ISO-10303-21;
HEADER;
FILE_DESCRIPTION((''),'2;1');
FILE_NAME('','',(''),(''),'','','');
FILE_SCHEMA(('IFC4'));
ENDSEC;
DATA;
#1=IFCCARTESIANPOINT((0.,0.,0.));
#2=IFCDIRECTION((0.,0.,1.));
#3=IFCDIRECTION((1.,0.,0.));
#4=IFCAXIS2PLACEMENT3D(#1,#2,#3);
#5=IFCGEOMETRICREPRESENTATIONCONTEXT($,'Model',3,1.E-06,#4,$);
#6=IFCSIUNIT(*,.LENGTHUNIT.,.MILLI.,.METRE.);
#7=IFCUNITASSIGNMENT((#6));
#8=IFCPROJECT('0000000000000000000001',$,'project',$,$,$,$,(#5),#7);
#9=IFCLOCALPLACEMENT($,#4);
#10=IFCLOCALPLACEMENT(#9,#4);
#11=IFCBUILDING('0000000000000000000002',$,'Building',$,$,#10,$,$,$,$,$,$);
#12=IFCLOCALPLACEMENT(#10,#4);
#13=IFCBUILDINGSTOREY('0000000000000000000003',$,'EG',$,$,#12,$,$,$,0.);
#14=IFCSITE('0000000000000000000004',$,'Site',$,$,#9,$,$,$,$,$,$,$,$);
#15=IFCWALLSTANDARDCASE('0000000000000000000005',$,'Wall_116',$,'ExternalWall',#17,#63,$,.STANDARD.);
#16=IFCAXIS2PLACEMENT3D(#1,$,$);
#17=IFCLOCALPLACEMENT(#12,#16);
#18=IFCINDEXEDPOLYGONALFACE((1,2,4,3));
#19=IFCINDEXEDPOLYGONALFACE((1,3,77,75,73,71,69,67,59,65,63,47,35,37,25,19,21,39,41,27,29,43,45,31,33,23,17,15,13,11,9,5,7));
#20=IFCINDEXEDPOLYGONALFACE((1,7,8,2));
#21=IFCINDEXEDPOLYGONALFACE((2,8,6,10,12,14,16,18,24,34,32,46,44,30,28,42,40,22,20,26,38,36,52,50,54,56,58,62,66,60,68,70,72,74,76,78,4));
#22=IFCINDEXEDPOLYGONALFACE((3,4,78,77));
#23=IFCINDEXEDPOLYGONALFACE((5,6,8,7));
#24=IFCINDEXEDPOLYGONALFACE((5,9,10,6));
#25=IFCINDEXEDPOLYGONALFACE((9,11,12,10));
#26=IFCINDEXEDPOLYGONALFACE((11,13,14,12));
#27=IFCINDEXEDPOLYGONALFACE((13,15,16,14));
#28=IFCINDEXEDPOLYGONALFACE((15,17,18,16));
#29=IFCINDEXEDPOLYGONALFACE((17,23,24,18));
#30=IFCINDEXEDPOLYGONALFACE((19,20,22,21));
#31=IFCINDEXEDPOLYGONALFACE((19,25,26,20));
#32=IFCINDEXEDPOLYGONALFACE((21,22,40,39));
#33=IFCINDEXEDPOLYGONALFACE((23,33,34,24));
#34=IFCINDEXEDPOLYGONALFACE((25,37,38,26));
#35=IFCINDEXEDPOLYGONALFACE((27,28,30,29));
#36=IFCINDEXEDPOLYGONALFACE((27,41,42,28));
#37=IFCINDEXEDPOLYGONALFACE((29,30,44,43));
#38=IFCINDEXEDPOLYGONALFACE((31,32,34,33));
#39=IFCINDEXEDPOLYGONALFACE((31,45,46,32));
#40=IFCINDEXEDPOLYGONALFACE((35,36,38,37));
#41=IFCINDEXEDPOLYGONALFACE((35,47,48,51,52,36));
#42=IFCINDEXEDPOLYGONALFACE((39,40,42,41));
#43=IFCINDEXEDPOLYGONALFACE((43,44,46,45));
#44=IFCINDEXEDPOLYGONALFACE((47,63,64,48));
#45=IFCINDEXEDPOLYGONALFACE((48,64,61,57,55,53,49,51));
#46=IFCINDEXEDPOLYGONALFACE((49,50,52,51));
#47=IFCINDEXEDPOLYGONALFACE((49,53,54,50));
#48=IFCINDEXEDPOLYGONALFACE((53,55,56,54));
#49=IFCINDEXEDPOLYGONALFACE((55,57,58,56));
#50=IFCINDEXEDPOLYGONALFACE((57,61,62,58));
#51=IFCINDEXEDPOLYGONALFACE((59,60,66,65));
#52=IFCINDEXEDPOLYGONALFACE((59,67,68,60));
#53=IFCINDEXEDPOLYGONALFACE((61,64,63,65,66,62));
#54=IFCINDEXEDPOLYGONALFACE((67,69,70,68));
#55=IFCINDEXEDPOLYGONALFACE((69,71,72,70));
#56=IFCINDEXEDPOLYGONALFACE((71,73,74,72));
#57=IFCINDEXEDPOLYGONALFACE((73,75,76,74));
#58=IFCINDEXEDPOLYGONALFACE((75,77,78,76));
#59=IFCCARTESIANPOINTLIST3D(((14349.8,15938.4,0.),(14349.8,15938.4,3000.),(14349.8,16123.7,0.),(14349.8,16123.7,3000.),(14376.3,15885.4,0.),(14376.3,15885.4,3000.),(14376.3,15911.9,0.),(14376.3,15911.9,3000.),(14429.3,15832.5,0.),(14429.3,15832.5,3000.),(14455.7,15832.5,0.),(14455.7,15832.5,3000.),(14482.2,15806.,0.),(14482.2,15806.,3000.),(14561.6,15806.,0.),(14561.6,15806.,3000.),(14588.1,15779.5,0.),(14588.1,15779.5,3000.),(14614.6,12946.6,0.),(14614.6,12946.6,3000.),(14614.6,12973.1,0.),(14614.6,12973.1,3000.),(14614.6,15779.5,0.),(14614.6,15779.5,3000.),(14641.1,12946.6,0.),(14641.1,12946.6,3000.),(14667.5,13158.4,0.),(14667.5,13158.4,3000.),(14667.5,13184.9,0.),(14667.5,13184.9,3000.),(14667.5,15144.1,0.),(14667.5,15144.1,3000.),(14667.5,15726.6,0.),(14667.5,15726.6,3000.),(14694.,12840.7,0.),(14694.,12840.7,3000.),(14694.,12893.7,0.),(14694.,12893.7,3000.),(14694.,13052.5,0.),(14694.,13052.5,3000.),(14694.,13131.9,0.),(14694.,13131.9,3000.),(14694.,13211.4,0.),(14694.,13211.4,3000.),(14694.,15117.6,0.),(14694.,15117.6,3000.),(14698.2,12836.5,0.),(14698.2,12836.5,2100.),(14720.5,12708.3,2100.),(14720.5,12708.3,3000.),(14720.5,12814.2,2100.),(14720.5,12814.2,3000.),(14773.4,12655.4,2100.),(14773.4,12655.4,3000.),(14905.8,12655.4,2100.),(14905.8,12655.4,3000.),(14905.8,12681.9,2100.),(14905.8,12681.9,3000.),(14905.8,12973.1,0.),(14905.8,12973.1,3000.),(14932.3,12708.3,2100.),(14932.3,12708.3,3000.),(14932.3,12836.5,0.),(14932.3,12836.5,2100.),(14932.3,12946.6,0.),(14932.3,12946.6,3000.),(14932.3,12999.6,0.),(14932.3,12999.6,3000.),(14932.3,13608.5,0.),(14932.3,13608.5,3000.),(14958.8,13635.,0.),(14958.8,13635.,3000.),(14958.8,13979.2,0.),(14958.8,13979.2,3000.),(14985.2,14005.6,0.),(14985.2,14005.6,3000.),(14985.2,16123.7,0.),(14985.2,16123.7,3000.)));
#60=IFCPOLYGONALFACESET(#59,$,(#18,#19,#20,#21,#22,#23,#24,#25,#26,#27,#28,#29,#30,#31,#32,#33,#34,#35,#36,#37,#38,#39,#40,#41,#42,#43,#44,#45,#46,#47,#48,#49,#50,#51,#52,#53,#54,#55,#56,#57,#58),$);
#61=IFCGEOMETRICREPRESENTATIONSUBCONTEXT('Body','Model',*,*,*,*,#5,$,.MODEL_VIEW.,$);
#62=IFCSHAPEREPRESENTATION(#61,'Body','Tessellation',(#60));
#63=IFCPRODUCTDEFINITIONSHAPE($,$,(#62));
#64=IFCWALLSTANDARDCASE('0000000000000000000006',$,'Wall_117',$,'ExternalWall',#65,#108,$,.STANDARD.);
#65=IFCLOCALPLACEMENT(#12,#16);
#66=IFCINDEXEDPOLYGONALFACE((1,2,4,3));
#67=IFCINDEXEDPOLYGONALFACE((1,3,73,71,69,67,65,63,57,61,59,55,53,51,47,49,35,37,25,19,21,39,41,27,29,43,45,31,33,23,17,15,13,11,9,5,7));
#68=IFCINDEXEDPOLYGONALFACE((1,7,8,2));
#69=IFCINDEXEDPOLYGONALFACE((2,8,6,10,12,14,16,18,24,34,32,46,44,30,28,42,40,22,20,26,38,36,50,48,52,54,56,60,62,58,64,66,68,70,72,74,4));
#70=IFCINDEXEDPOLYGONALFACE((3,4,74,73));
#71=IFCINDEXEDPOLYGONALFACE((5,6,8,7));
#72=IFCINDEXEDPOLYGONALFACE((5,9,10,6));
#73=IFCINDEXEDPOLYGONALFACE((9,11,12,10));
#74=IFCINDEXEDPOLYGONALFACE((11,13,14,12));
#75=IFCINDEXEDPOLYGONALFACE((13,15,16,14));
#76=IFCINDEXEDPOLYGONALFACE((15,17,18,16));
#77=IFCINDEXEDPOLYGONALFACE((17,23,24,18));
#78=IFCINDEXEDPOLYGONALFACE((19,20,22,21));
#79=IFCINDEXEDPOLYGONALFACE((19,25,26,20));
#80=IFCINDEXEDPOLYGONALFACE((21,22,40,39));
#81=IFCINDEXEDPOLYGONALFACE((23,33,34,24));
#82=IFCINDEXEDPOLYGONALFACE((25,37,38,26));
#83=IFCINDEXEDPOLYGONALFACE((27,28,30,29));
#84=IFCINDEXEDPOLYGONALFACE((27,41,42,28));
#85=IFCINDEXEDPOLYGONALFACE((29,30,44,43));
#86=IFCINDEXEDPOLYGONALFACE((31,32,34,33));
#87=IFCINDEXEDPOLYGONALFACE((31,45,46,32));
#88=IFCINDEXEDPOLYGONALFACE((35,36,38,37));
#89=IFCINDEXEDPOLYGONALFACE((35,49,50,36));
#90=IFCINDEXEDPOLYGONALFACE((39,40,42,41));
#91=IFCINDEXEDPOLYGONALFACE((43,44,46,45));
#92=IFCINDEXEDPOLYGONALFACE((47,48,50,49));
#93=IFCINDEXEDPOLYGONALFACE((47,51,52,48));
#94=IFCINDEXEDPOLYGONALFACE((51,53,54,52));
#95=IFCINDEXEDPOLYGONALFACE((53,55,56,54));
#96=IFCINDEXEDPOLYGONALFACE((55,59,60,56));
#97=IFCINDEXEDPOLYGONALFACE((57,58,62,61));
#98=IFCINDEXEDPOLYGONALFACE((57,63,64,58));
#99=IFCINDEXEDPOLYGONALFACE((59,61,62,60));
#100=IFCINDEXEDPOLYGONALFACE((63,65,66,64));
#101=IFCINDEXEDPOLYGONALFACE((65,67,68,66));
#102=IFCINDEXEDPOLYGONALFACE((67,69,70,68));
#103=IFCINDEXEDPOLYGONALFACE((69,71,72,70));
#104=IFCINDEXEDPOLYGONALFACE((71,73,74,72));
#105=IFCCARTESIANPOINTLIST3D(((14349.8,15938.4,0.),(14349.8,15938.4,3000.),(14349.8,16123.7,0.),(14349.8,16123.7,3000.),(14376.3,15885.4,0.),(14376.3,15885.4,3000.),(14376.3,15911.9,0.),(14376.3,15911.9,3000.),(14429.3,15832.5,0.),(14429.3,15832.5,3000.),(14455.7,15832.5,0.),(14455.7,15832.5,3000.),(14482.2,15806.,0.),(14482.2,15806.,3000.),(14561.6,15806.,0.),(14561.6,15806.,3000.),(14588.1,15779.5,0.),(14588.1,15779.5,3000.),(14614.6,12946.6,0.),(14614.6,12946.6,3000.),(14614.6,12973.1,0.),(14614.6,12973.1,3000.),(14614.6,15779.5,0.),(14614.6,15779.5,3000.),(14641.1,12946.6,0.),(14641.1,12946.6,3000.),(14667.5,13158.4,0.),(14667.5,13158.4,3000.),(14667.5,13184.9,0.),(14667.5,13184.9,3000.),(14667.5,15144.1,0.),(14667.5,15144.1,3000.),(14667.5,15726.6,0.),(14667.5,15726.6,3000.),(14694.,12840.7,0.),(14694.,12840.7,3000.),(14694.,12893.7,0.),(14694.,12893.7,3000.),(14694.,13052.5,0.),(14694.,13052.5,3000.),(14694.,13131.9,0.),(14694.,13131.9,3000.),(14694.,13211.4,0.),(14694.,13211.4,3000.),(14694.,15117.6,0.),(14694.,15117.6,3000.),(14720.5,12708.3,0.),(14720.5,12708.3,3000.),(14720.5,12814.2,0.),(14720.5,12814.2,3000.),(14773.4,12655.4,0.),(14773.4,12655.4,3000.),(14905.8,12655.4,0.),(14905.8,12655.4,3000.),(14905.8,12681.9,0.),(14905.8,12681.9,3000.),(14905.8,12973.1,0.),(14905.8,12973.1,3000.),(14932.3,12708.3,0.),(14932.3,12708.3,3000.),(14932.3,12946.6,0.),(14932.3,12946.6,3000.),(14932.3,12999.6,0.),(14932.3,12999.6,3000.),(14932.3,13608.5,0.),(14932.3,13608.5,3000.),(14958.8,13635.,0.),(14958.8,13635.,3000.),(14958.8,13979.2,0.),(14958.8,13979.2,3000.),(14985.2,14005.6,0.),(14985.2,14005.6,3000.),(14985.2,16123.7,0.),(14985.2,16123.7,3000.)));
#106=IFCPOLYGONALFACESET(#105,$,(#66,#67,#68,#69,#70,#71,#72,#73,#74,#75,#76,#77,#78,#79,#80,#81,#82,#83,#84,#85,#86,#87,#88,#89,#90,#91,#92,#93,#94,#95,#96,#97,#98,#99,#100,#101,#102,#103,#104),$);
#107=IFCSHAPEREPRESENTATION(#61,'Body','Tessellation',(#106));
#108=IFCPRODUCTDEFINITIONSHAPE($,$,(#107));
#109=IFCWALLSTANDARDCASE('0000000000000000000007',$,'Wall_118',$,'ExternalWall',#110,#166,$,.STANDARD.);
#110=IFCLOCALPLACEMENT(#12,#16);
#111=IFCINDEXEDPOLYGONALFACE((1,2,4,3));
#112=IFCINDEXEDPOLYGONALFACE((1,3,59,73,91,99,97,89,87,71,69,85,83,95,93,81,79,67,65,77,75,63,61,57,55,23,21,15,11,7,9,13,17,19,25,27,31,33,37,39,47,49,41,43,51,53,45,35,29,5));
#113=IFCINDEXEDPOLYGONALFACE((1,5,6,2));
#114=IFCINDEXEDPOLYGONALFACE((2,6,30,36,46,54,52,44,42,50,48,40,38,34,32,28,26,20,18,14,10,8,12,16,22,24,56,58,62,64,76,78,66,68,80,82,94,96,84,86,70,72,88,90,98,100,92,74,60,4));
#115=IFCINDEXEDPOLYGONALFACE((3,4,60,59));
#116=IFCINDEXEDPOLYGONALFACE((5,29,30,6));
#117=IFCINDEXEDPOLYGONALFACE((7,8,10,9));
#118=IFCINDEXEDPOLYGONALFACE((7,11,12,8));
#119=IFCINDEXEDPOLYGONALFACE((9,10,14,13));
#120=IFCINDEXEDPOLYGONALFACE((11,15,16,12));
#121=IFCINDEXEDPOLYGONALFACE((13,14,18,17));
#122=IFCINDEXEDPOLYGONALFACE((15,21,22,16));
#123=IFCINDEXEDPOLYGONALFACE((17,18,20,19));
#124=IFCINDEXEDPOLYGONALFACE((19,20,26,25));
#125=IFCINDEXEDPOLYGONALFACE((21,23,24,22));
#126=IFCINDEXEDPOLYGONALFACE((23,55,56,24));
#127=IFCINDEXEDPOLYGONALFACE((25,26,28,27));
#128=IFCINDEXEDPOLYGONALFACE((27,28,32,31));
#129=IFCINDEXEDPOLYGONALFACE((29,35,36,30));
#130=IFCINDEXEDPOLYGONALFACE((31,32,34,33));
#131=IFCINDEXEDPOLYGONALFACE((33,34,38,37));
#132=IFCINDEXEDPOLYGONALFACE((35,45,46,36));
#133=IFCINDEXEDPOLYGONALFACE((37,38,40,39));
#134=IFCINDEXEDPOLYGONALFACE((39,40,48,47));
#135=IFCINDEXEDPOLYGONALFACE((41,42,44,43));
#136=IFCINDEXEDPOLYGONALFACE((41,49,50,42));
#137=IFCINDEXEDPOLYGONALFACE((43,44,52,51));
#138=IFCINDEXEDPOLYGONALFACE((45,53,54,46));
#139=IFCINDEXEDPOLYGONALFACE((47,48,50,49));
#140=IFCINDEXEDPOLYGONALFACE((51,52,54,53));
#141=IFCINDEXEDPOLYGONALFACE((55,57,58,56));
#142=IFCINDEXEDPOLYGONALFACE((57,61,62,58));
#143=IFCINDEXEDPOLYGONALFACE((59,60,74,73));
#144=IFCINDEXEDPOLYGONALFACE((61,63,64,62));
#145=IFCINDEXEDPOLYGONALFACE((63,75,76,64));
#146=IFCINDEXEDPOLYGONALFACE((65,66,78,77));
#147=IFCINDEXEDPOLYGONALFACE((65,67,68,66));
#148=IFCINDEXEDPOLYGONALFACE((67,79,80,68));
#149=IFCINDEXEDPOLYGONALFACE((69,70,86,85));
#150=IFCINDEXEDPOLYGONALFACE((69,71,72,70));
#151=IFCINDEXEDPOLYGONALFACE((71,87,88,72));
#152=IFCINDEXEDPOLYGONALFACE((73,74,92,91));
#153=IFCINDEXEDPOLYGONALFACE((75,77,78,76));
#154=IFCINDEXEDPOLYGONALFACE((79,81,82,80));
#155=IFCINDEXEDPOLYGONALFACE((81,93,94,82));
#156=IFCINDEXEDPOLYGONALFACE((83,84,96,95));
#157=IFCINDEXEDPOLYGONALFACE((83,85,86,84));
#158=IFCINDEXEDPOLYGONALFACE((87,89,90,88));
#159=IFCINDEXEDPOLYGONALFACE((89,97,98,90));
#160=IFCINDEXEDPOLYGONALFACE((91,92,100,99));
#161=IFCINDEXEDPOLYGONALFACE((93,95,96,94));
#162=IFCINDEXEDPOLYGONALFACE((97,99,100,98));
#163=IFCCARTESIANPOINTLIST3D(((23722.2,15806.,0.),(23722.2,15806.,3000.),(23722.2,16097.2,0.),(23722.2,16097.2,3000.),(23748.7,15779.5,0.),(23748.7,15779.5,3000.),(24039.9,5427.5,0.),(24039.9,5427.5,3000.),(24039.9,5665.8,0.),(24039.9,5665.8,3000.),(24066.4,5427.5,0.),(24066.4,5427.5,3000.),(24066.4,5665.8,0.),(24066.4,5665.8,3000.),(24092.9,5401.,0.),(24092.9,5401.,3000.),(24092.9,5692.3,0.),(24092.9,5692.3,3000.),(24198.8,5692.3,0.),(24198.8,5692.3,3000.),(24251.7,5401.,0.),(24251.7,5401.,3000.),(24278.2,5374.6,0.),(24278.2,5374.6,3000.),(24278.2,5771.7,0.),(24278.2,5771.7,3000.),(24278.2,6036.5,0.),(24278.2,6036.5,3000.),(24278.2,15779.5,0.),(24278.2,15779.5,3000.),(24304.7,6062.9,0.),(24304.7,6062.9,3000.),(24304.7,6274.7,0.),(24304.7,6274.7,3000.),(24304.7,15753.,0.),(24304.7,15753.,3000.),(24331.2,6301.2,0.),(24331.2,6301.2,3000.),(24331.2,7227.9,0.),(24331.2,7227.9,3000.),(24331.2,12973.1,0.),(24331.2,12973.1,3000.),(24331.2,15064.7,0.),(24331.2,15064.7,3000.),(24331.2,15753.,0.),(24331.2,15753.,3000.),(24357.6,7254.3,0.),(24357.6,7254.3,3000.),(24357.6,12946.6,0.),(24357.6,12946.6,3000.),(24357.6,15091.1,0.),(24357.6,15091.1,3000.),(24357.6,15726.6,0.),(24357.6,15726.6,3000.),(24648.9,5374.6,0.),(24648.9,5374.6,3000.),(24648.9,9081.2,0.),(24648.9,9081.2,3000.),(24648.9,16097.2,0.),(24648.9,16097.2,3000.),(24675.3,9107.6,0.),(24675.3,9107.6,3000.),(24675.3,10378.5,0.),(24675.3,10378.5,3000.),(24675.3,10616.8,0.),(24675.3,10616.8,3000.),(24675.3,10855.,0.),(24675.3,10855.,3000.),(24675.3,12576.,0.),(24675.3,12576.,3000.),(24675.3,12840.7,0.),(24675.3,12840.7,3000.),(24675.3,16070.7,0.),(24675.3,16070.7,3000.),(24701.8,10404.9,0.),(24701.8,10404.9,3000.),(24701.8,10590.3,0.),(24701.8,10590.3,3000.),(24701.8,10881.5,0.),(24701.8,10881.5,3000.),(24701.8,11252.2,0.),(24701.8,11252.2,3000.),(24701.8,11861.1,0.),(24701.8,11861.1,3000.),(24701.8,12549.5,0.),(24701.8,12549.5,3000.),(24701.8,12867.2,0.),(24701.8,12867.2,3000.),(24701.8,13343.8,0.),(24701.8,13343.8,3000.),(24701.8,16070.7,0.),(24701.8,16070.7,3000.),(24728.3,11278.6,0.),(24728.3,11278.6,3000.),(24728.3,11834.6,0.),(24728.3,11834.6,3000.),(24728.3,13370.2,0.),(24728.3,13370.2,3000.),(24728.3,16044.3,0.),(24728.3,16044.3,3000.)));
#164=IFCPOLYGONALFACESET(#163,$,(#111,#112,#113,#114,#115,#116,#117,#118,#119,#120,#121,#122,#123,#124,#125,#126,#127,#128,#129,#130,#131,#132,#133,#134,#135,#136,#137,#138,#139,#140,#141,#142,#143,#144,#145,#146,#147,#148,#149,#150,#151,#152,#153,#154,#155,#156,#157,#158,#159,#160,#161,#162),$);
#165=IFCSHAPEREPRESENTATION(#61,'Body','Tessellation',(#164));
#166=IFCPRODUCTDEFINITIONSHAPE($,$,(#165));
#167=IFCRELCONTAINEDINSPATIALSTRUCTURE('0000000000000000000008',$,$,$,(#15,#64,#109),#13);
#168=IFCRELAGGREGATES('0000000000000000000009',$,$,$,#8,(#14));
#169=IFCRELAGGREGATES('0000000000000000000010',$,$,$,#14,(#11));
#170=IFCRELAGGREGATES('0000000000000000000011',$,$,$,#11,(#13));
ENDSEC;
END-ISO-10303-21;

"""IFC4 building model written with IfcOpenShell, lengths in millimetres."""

from ifc_helpers import new_model, si_unit, frame, origin_with_axes, place, context, subcontext, project, spatial, polyline, rectangle, outline, extrude, element, save


model = new_model("IFC4")

# Units and contexts
model_context = context("Model", 3, precision=1e-06, world=origin_with_axes())
body_context = subcontext(model_context, "Body", "Model", "MODEL_VIEW")
ifc_project = project(units=[si_unit("LENGTHUNIT", "METRE", prefix="MILLI")], contexts=[model_context])

# Site, building, storey
site_placement = place(None, origin_with_axes())
site = spatial("IfcSite", under=ifc_project, at=site_placement, Name="Site")
building_placement = place(site_placement, origin_with_axes())
building = spatial("IfcBuilding", under=site, at=building_placement, Name="Building")
storey_placement = place(building_placement, origin_with_axes())
storey = spatial("IfcBuildingStorey", under=building, at=storey_placement, Name="EG", Elevation=0.0)

# Wall, opening
wall_1_placement = place(storey_placement, origin_with_axes())
wall_1 = element("IfcWallStandardCase", 1, at=wall_1_placement, inside=storey, Name="Wall_116", ObjectType="ExternalWall", PredefinedType="STANDARD", context=body_context, shape_type="SweptSolid", body=[
    extrude(outline(polyline([(14773.4, 12655.4, 0.0), (14720.5, 12708.3, 0.0), (14720.5, 12814.2, 0.0), (14694.0, 12840.7, 0.0), (14694.0, 12893.7, 0.0), (14641.1, 12946.6, 0.0), (14614.6, 12946.6, 0.0), (14614.6, 12973.1, 0.0), (14694.0, 13052.5, 0.0), (14694.0, 13131.9, 0.0), (14667.5, 13158.4, 0.0), (14667.5, 13184.9, 0.0), (14694.0, 13211.4, 0.0), (14694.0, 15117.6, 0.0), (14667.5, 15144.1, 0.0), (14667.5, 15726.6, 0.0), (14614.6, 15779.5, 0.0), (14588.1, 15779.5, 0.0), (14561.6, 15806.0, 0.0), (14482.2, 15806.0, 0.0), (14455.7, 15832.5, 0.0), (14429.3, 15832.5, 0.0), (14376.3, 15885.4, 0.0), (14376.3, 15911.9, 0.0), (14349.8, 15938.4, 0.0), (14349.8, 16123.7, 0.0), (14985.2, 16123.7, 0.0), (14985.2, 14005.6, 0.0), (14958.8, 13979.2, 0.0), (14958.8, 13635.0, 0.0), (14932.3, 13608.5, 0.0), (14932.3, 12999.6, 0.0), (14905.8, 12973.1, 0.0), (14932.3, 12946.6, 0.0), (14932.3, 12708.3, 0.0), (14905.8, 12681.9, 0.0), (14905.8, 12655.4, 0.0), (14773.4, 12655.4, 0.0)])), origin_with_axes(), (0.0, 0.0, 1.0), 3000.0),
])
opening_1_placement = place(wall_1_placement, origin_with_axes())
element("IfcOpeningElement", 2, at=opening_1_placement, inside=storey, cuts=wall_1, context=body_context, shape_type="SweptSolid", body=[
    extrude(rectangle(XDim=1059.0, YDim=240.0), frame((14772.0, 12716.5, 0.0), z_axis=(0.0, 0.0, 1.0), x_axis=(1.0, 0.0, 0.0)), (0.0, 0.0, 1.0), 2100.0),
])

# Walls
wall_2_placement = place(storey_placement, origin_with_axes())
element("IfcWallStandardCase", 3, at=wall_2_placement, inside=storey, Name="Wall_117", ObjectType="ExternalWall", PredefinedType="STANDARD", context=body_context, shape_type="SweptSolid", body=[
    extrude(outline(polyline([(14773.4, 12655.4, 0.0), (14720.5, 12708.3, 0.0), (14720.5, 12814.2, 0.0), (14694.0, 12840.7, 0.0), (14694.0, 12893.7, 0.0), (14641.1, 12946.6, 0.0), (14614.6, 12946.6, 0.0), (14614.6, 12973.1, 0.0), (14694.0, 13052.5, 0.0), (14694.0, 13131.9, 0.0), (14667.5, 13158.4, 0.0), (14667.5, 13184.9, 0.0), (14694.0, 13211.4, 0.0), (14694.0, 15117.6, 0.0), (14667.5, 15144.1, 0.0), (14667.5, 15726.6, 0.0), (14614.6, 15779.5, 0.0), (14588.1, 15779.5, 0.0), (14561.6, 15806.0, 0.0), (14482.2, 15806.0, 0.0), (14455.7, 15832.5, 0.0), (14429.3, 15832.5, 0.0), (14376.3, 15885.4, 0.0), (14376.3, 15911.9, 0.0), (14349.8, 15938.4, 0.0), (14349.8, 16123.7, 0.0), (14985.2, 16123.7, 0.0), (14985.2, 14005.6, 0.0), (14958.8, 13979.2, 0.0), (14958.8, 13635.0, 0.0), (14932.3, 13608.5, 0.0), (14932.3, 12999.6, 0.0), (14905.8, 12973.1, 0.0), (14932.3, 12946.6, 0.0), (14932.3, 12708.3, 0.0), (14905.8, 12681.9, 0.0), (14905.8, 12655.4, 0.0), (14773.4, 12655.4, 0.0)])), origin_with_axes(), (0.0, 0.0, 1.0), 3000.0),
])
wall_3_placement = place(storey_placement, origin_with_axes())
element("IfcWallStandardCase", 4, at=wall_3_placement, inside=storey, Name="Wall_118", ObjectType="ExternalWall", PredefinedType="STANDARD", context=body_context, shape_type="SweptSolid", body=[
    extrude(outline(polyline([(24278.2, 5374.6, 0.0), (24251.7, 5401.0, 0.0), (24092.9, 5401.0, 0.0), (24066.4, 5427.5, 0.0), (24039.9, 5427.5, 0.0), (24039.9, 5665.8, 0.0), (24066.4, 5665.8, 0.0), (24092.9, 5692.3, 0.0), (24198.8, 5692.3, 0.0), (24278.2, 5771.7, 0.0), (24278.2, 6036.5, 0.0), (24304.7, 6062.9, 0.0), (24304.7, 6274.7, 0.0), (24331.2, 6301.2, 0.0), (24331.2, 7227.9, 0.0), (24357.6, 7254.3, 0.0), (24357.6, 12946.6, 0.0), (24331.2, 12973.1, 0.0), (24331.2, 15064.7, 0.0), (24357.6, 15091.1, 0.0), (24357.6, 15726.6, 0.0), (24331.2, 15753.0, 0.0), (24304.7, 15753.0, 0.0), (24278.2, 15779.5, 0.0), (23748.7, 15779.5, 0.0), (23722.2, 15806.0, 0.0), (23722.2, 16097.2, 0.0), (24648.9, 16097.2, 0.0), (24675.3, 16070.7, 0.0), (24701.8, 16070.7, 0.0), (24728.3, 16044.3, 0.0), (24728.3, 13370.2, 0.0), (24701.8, 13343.8, 0.0), (24701.8, 12867.2, 0.0), (24675.3, 12840.7, 0.0), (24675.3, 12576.0, 0.0), (24701.8, 12549.5, 0.0), (24701.8, 11861.1, 0.0), (24728.3, 11834.6, 0.0), (24728.3, 11278.6, 0.0), (24701.8, 11252.2, 0.0), (24701.8, 10881.5, 0.0), (24675.3, 10855.0, 0.0), (24675.3, 10616.8, 0.0), (24701.8, 10590.3, 0.0), (24701.8, 10404.9, 0.0), (24675.3, 10378.5, 0.0), (24675.3, 9107.6, 0.0), (24648.9, 9081.2, 0.0), (24648.9, 5374.6, 0.0), (24278.2, 5374.6, 0.0)])), origin_with_axes(), (0.0, 0.0, 1.0), 3000.0),
])

save(model, "model.ifc")
